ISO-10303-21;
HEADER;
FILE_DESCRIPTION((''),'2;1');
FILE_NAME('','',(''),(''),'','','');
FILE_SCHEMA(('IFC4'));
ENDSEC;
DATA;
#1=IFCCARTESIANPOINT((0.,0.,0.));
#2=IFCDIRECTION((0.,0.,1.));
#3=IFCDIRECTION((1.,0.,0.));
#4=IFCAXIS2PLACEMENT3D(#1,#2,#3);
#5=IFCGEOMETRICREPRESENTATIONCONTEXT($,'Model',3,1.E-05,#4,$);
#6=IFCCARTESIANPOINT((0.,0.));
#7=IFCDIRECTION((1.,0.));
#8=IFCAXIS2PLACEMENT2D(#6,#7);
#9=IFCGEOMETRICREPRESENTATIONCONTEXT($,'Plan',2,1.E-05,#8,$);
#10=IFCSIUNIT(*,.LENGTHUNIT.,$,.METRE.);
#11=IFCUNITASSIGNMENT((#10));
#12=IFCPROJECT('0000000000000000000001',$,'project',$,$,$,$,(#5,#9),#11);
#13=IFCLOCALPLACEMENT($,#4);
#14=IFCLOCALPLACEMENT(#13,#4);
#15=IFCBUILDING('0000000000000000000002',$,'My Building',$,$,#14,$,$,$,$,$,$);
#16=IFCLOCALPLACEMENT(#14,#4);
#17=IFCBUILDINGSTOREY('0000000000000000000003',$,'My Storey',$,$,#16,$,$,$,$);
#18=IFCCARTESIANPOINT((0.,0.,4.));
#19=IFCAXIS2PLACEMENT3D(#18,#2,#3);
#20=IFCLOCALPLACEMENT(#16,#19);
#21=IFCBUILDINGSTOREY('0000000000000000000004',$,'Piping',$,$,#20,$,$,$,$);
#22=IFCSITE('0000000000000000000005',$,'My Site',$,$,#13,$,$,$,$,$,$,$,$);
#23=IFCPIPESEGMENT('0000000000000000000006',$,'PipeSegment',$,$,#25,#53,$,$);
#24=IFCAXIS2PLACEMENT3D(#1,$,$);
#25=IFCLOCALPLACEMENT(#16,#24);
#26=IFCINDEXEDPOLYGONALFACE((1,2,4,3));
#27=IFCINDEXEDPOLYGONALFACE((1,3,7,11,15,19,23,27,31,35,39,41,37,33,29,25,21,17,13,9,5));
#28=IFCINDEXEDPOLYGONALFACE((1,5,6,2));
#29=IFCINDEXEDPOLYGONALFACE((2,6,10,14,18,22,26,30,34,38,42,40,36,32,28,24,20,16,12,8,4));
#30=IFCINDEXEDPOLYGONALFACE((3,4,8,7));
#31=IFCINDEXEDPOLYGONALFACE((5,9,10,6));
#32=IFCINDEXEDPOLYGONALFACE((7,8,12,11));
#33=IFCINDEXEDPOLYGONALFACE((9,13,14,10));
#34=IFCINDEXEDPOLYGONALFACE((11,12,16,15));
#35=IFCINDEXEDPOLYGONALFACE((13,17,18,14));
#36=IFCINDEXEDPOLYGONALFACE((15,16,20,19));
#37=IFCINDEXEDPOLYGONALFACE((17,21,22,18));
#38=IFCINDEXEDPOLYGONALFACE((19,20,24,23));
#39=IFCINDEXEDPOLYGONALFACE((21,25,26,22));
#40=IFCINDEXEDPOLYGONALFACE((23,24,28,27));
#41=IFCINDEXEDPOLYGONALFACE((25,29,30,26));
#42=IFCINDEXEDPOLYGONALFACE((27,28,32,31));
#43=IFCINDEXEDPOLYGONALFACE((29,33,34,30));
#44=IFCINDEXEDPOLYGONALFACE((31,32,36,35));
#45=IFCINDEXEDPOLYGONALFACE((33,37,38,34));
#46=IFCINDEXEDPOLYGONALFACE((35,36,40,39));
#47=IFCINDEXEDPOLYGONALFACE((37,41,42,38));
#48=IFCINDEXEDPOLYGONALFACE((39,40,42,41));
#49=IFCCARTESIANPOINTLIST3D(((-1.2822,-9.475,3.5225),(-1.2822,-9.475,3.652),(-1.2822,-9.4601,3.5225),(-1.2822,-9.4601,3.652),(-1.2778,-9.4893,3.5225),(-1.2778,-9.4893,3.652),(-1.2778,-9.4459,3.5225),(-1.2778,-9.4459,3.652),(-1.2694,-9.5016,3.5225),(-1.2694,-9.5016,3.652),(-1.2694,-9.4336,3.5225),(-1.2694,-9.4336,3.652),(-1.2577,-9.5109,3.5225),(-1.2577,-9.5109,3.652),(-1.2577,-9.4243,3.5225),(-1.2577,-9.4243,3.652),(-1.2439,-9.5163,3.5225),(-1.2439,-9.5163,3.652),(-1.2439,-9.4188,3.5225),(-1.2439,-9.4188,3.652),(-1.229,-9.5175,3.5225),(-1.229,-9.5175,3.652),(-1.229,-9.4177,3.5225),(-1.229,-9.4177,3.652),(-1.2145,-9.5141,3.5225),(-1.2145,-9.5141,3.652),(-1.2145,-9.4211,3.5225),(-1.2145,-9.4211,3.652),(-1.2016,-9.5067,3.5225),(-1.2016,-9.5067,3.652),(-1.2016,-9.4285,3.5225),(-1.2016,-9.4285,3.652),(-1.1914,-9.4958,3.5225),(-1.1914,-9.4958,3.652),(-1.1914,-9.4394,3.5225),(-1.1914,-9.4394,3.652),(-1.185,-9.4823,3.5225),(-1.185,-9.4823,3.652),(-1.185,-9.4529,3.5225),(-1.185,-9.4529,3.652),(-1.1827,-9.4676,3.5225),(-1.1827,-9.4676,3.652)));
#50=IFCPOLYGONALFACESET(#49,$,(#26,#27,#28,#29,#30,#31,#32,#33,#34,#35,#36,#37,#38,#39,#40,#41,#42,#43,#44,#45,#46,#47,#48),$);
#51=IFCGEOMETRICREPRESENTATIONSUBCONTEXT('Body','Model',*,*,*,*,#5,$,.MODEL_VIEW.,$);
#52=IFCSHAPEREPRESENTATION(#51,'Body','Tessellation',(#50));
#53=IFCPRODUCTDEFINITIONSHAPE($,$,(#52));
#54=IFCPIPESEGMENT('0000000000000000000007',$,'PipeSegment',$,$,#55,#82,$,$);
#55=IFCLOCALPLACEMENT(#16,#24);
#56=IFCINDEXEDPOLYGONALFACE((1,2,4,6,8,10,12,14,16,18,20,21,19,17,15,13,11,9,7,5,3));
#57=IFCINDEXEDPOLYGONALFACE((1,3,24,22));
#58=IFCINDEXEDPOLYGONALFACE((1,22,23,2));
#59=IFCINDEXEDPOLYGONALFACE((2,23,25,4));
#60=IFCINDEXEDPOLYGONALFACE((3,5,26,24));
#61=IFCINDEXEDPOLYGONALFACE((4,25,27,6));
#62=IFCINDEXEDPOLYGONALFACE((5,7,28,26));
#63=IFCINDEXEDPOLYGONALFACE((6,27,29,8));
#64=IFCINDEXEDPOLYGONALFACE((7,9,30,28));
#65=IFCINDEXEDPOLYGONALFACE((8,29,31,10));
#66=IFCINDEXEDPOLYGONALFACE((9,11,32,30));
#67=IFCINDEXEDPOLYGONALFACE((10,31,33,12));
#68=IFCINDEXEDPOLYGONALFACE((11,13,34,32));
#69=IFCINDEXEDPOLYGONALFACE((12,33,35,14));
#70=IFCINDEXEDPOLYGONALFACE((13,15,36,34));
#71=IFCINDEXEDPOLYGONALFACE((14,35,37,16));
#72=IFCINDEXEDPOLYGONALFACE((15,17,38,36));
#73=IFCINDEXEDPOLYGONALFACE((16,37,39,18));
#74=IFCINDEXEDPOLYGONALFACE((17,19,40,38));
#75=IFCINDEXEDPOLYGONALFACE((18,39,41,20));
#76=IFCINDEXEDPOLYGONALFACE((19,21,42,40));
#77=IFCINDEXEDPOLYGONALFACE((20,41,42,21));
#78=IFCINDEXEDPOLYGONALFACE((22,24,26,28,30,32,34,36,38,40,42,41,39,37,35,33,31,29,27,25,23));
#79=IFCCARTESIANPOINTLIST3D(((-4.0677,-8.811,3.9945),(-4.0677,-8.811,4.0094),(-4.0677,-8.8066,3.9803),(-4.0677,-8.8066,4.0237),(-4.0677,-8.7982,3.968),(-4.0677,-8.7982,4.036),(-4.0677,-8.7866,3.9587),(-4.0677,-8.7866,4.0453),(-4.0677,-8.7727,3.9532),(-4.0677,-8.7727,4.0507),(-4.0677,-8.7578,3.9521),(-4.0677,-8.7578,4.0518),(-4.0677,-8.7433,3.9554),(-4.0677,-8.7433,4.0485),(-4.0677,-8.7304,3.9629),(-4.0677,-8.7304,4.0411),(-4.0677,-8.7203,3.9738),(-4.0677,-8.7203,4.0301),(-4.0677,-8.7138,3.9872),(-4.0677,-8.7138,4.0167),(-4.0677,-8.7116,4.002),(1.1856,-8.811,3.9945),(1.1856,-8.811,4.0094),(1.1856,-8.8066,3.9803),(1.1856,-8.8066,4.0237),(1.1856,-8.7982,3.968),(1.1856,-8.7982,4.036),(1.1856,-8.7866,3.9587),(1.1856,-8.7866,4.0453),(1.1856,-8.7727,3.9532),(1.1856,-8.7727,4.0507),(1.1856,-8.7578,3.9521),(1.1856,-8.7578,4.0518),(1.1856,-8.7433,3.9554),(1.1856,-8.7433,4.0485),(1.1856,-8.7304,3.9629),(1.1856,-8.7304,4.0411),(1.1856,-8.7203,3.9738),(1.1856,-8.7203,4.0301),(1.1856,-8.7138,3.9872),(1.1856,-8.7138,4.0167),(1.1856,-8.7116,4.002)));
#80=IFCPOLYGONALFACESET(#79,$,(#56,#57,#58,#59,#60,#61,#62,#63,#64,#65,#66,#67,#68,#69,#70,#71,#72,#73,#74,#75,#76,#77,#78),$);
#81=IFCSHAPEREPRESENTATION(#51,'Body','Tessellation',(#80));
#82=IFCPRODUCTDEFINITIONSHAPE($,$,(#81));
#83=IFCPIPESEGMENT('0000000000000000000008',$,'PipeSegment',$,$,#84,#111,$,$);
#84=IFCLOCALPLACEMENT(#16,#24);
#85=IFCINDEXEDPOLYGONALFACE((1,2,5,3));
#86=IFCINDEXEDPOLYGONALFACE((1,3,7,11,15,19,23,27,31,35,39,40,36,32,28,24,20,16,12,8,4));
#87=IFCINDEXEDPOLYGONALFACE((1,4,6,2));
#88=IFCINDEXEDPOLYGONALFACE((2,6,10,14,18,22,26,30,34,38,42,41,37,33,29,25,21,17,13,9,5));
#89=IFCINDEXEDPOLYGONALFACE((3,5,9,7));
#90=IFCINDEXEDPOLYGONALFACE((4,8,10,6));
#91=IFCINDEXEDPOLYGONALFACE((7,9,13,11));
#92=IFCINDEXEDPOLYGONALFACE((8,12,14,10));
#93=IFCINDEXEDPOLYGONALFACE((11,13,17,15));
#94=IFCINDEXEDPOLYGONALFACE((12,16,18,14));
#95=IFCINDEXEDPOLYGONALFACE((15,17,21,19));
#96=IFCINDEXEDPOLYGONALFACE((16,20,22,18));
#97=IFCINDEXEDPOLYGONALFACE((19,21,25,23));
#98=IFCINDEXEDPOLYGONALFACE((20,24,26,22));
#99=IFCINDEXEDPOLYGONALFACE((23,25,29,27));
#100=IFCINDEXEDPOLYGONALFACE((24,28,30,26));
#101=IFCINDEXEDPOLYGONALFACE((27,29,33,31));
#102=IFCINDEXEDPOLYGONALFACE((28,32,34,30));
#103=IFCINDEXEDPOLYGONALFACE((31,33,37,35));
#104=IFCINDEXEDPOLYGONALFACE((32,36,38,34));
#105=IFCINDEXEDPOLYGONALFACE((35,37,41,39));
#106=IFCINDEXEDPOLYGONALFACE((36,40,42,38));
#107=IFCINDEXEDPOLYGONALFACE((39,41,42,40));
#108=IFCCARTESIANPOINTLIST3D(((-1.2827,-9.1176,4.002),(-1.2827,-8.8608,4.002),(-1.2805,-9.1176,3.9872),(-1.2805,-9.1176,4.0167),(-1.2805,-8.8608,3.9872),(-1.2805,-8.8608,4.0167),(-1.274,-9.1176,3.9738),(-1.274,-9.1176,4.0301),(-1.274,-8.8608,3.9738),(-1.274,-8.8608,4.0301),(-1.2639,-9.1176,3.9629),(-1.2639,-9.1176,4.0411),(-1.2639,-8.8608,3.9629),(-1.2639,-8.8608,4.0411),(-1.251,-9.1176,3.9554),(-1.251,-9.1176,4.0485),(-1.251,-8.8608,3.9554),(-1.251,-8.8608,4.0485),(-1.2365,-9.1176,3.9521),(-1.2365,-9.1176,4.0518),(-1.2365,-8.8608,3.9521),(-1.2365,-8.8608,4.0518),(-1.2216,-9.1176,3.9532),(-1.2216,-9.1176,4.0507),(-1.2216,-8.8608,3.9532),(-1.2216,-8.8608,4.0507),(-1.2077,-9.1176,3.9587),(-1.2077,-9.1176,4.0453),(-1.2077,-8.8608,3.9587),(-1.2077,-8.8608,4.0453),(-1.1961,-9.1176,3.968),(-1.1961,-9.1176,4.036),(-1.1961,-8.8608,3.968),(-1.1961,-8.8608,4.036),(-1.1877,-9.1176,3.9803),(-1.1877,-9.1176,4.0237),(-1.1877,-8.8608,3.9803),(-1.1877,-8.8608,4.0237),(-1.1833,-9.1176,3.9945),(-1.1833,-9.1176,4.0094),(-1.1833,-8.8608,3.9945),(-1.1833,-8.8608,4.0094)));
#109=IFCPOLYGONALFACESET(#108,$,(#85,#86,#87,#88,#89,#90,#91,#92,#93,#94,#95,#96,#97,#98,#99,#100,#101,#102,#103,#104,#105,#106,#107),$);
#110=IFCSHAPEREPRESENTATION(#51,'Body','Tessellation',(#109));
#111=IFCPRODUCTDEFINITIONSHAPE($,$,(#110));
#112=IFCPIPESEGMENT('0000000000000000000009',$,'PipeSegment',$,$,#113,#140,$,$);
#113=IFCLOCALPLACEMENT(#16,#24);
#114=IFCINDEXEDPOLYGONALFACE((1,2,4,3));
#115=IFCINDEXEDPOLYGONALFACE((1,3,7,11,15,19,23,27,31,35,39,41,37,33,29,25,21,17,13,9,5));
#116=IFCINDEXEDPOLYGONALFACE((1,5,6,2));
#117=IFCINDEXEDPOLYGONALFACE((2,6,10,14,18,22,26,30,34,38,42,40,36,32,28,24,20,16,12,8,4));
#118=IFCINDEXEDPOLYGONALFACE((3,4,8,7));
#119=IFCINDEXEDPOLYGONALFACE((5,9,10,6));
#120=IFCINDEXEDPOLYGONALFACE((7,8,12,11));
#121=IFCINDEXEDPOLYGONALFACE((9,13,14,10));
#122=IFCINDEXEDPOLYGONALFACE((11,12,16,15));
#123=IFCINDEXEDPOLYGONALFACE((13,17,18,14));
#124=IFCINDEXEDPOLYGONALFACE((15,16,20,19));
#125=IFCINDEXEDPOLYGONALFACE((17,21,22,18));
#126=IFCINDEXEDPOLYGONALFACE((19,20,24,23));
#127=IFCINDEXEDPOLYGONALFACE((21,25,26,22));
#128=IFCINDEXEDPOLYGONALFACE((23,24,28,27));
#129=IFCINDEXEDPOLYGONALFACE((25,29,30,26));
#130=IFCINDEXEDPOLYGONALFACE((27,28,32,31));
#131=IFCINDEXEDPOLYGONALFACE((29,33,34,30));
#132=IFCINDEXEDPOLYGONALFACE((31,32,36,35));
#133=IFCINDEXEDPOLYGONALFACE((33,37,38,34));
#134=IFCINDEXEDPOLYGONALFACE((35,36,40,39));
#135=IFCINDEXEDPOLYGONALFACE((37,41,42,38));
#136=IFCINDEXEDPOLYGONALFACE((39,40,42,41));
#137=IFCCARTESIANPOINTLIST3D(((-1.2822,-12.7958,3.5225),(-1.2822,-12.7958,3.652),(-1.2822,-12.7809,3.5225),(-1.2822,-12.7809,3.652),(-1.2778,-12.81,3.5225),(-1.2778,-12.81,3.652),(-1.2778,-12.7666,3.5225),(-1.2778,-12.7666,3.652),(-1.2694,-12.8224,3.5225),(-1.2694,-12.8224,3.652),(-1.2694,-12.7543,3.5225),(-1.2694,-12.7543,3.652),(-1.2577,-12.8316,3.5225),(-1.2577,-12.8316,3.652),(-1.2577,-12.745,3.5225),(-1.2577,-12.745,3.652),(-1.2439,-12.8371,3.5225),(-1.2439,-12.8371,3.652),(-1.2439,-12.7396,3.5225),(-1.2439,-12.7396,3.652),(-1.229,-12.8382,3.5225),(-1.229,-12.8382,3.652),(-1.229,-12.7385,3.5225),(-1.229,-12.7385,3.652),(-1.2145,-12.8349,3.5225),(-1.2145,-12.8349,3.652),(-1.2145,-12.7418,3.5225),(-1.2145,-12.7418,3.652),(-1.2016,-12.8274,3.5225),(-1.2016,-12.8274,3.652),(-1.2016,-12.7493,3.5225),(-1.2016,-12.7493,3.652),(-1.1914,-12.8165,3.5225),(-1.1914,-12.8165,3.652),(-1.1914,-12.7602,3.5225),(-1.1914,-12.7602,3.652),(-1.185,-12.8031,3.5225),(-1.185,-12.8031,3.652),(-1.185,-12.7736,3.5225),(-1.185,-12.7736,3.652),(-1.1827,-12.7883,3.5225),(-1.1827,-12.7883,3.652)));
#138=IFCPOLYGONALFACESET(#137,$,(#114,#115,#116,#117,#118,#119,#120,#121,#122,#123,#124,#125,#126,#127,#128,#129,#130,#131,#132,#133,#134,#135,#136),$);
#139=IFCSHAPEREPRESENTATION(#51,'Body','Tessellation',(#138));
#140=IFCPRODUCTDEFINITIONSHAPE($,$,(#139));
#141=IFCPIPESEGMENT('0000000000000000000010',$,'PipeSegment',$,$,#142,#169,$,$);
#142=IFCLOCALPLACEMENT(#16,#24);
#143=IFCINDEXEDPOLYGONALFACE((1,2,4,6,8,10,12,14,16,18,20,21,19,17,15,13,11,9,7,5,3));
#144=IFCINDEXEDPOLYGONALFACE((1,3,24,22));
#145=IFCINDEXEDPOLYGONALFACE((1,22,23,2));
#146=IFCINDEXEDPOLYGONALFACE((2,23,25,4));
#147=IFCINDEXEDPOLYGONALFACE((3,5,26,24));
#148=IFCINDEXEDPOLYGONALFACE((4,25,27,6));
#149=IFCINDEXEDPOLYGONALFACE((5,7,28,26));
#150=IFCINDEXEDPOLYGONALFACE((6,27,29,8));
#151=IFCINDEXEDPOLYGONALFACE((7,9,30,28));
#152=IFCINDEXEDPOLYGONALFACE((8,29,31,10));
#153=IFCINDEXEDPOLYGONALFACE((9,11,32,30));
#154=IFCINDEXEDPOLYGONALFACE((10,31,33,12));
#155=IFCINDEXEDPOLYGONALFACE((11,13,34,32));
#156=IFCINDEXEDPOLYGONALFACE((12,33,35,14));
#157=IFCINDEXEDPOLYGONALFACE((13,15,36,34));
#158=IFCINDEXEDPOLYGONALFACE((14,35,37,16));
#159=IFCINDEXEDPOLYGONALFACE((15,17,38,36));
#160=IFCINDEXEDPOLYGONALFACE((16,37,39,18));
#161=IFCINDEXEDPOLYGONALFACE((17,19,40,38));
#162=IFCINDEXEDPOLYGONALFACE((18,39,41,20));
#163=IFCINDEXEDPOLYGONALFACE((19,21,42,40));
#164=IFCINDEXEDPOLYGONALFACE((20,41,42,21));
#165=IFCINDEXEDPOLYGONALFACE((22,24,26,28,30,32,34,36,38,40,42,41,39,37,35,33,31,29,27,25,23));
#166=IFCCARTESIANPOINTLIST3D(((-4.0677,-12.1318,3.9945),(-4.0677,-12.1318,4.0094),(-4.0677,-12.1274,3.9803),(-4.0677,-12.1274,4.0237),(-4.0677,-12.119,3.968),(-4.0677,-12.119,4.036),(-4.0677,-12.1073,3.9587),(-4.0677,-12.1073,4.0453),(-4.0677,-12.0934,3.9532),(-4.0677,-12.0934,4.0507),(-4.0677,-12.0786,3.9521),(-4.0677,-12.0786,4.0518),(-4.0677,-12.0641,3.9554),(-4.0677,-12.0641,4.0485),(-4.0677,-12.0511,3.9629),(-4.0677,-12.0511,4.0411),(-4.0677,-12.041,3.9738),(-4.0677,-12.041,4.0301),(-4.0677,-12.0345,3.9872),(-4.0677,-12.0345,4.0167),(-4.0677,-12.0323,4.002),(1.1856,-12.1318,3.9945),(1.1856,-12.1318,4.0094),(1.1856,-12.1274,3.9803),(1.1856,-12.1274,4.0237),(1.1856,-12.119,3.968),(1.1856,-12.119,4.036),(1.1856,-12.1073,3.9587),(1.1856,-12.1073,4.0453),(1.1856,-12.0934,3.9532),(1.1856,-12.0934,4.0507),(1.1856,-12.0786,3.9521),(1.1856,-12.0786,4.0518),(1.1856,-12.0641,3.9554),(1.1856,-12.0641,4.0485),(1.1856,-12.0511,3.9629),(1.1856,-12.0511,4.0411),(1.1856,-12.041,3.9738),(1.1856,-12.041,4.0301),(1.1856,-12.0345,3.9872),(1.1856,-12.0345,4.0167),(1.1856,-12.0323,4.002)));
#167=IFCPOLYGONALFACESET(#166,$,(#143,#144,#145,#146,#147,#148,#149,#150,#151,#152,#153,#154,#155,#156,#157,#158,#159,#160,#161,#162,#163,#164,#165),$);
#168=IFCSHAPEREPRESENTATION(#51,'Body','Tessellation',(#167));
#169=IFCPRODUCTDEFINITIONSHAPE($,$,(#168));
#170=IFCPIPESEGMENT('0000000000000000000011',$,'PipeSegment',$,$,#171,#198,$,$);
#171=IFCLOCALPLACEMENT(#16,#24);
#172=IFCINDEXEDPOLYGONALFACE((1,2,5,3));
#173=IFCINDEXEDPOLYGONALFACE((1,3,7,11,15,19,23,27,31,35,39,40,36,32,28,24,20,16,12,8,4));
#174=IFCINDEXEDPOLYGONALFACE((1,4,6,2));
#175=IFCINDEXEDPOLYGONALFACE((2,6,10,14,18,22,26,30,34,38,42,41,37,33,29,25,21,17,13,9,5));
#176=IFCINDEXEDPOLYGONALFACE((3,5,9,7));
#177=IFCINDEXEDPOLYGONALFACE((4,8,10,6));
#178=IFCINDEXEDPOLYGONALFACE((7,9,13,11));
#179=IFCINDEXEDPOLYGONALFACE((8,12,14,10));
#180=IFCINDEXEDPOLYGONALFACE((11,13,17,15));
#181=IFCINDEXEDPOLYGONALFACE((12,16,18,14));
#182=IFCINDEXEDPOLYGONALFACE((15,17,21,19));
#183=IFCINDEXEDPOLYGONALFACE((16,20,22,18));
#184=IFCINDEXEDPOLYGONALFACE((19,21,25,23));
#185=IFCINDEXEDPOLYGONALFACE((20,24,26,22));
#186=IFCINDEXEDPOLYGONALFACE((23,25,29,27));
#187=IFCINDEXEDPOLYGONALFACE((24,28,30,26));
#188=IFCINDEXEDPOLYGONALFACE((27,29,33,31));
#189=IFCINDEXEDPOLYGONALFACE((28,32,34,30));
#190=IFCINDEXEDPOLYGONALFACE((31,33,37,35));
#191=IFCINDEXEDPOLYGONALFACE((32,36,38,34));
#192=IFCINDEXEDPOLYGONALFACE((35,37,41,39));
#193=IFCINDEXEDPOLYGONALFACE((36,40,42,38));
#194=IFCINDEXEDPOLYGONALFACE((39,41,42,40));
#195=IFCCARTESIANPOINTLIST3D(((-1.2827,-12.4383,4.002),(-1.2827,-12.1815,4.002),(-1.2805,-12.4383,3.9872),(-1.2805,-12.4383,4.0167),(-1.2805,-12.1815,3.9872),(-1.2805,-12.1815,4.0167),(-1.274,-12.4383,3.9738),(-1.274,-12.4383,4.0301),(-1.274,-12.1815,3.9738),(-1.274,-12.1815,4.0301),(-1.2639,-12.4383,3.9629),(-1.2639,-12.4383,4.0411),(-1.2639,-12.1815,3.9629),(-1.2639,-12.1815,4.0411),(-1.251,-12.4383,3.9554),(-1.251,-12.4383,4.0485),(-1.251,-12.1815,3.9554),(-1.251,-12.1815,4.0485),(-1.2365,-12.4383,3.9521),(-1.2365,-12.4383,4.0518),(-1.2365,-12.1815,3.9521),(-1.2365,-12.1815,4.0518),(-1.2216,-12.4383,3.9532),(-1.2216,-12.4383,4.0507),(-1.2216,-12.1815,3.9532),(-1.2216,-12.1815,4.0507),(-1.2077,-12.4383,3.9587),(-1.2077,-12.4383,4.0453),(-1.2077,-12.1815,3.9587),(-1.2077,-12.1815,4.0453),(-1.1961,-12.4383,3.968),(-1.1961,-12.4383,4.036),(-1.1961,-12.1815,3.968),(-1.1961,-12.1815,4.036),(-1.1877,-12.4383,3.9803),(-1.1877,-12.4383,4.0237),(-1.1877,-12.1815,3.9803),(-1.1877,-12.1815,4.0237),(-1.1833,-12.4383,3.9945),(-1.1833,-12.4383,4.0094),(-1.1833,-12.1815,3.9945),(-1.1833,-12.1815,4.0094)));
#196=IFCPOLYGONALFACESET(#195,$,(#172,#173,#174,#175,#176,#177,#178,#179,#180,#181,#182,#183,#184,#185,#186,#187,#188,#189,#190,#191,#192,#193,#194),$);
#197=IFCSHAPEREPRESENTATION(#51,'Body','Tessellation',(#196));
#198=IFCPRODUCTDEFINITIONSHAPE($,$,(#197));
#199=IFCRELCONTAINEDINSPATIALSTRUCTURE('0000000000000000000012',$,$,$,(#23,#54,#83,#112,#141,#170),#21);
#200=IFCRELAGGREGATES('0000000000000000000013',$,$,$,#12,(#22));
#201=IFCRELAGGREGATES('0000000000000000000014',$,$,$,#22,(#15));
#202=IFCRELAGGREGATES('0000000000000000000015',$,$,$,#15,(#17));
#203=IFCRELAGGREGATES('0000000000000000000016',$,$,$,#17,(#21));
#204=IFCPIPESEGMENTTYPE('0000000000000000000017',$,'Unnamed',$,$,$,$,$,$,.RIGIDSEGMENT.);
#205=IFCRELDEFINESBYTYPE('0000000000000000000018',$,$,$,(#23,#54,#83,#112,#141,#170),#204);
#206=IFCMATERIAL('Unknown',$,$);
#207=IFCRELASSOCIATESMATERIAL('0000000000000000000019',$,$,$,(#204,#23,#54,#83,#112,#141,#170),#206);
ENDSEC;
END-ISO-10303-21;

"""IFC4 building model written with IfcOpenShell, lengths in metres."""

from ifc_helpers import new_model, si_unit, frame, origin_with_axes, origin_2d_with_axis, place, context, subcontext, project, spatial, circle, extrude, material, material_profile, profile_set, profile_usage, type_object, element, save


model = new_model("IFC4")

# Units and contexts
model_context = context("Model", 3, precision=1e-05, world=origin_with_axes())
plan_context = context("Plan", 2, precision=1e-05, world=origin_2d_with_axis())
body_context = subcontext(model_context, "Body", "Model", "MODEL_VIEW")
ifc_project = project(units=[si_unit("LENGTHUNIT", "METRE")], contexts=[model_context, plan_context])

# Site, building, storeys
site_placement = place(None, origin_with_axes())
site = spatial("IfcSite", under=ifc_project, at=site_placement, Name="My Site")
building_placement = place(site_placement, origin_with_axes())
building = spatial("IfcBuilding", under=site, at=building_placement, Name="My Building")
storey_1_placement = place(building_placement, origin_with_axes())
storey_1 = spatial("IfcBuildingStorey", under=building, at=storey_1_placement, Name="My Storey")
storey_2_placement = place(storey_1_placement, frame((0.0, 0.0, 4.0), z_axis=(0.0, 0.0, 1.0), x_axis=(1.0, 0.0, 0.0)))
storey_2 = spatial("IfcBuildingStorey", under=storey_1, at=storey_2_placement, Name="Piping")

# Pipe segments
ifc_material = material(Name="Unknown")
ifc_material_profile_1 = material_profile(ifc_material, circle(Radius=0.05))
ifc_profile_set_1 = profile_set([ifc_material_profile_1])
pipe_segment_type = type_object("IfcPipeSegmentType", Name="Unnamed", PredefinedType="RIGIDSEGMENT", material=ifc_profile_set_1)
ifc_profile_usage_1 = profile_usage(ifc_profile_set_1, cardinal=5)
pipe_segment_1_placement = place(storey_2_placement, frame((-1.2327, -9.4676, -0.348), z_axis=(0.0, 0.0, -1.0), x_axis=(1.0, 0.0, 0.0)))
element("IfcPipeSegment", 1, at=pipe_segment_1_placement, inside=storey_2, type_object=pipe_segment_type, material=ifc_profile_usage_1, Name="PipeSegment", context=body_context, shape_type="SweptSolid", body=[
    extrude(circle(Radius=0.05), origin_with_axes(), (0.0, 0.0, 1.0), 0.1294),
])
ifc_profile_usage_2 = profile_usage(ifc_profile_set_1, cardinal=5)
pipe_segment_2_placement = place(storey_2_placement, frame((-4.0677, -8.7616, 0.002), z_axis=(1.0, 0.0, 0.0), x_axis=(0.0, 1.0, 0.0)))
element("IfcPipeSegment", 2, at=pipe_segment_2_placement, inside=storey_2, type_object=pipe_segment_type, material=ifc_profile_usage_2, Name="PipeSegment", context=body_context, shape_type="SweptSolid", body=[
    extrude(circle(Radius=0.05), origin_with_axes(), (0.0, 0.0, 1.0), 5.2533),
])
ifc_profile_usage_3 = profile_usage(ifc_profile_set_1, cardinal=5)
pipe_segment_3_placement = place(storey_2_placement, frame((-1.2327, -9.1176, 0.002), z_axis=(0.0, 1.0, 0.000001), x_axis=(-1.0, 0.0, 0.0)))
element("IfcPipeSegment", 3, at=pipe_segment_3_placement, inside=storey_2, type_object=pipe_segment_type, material=ifc_profile_usage_3, Name="PipeSegment", context=body_context, shape_type="SweptSolid", body=[
    extrude(circle(Radius=0.05), origin_with_axes(), (0.0, 0.0, 1.0), 0.2568),
])
ifc_profile_usage_4 = profile_usage(ifc_profile_set_1, cardinal=5)
pipe_segment_4_placement = place(storey_2_placement, frame((-1.2327, -12.7883, -0.348), z_axis=(0.0, 0.0, -1.0), x_axis=(1.0, 0.0, 0.0)))
element("IfcPipeSegment", 4, at=pipe_segment_4_placement, inside=storey_2, type_object=pipe_segment_type, material=ifc_profile_usage_4, Name="PipeSegment", context=body_context, shape_type="SweptSolid", body=[
    extrude(circle(Radius=0.05), origin_with_axes(), (0.0, 0.0, 1.0), 0.1294),
])
ifc_profile_usage_5 = profile_usage(ifc_profile_set_1, cardinal=5)
pipe_segment_5_placement = place(storey_2_placement, frame((-4.0677, -12.0823, 0.002), z_axis=(1.0, 0.0, 0.0), x_axis=(0.0, 1.0, 0.0)))
element("IfcPipeSegment", 5, at=pipe_segment_5_placement, inside=storey_2, type_object=pipe_segment_type, material=ifc_profile_usage_5, Name="PipeSegment", context=body_context, shape_type="SweptSolid", body=[
    extrude(circle(Radius=0.05), origin_with_axes(), (0.0, 0.0, 1.0), 5.2533),
])
ifc_profile_usage_6 = profile_usage(ifc_profile_set_1, cardinal=5)
pipe_segment_6_placement = place(storey_2_placement, frame((-1.2327, -12.4383, 0.002), z_axis=(0.0, 1.0, 0.000001), x_axis=(-1.0, 0.0, 0.0)))
element("IfcPipeSegment", 6, at=pipe_segment_6_placement, inside=storey_2, type_object=pipe_segment_type, material=ifc_profile_usage_6, Name="PipeSegment", context=body_context, shape_type="SweptSolid", body=[
    extrude(circle(Radius=0.05), origin_with_axes(), (0.0, 0.0, 1.0), 0.2568),
])

save(model, "model.ifc")
